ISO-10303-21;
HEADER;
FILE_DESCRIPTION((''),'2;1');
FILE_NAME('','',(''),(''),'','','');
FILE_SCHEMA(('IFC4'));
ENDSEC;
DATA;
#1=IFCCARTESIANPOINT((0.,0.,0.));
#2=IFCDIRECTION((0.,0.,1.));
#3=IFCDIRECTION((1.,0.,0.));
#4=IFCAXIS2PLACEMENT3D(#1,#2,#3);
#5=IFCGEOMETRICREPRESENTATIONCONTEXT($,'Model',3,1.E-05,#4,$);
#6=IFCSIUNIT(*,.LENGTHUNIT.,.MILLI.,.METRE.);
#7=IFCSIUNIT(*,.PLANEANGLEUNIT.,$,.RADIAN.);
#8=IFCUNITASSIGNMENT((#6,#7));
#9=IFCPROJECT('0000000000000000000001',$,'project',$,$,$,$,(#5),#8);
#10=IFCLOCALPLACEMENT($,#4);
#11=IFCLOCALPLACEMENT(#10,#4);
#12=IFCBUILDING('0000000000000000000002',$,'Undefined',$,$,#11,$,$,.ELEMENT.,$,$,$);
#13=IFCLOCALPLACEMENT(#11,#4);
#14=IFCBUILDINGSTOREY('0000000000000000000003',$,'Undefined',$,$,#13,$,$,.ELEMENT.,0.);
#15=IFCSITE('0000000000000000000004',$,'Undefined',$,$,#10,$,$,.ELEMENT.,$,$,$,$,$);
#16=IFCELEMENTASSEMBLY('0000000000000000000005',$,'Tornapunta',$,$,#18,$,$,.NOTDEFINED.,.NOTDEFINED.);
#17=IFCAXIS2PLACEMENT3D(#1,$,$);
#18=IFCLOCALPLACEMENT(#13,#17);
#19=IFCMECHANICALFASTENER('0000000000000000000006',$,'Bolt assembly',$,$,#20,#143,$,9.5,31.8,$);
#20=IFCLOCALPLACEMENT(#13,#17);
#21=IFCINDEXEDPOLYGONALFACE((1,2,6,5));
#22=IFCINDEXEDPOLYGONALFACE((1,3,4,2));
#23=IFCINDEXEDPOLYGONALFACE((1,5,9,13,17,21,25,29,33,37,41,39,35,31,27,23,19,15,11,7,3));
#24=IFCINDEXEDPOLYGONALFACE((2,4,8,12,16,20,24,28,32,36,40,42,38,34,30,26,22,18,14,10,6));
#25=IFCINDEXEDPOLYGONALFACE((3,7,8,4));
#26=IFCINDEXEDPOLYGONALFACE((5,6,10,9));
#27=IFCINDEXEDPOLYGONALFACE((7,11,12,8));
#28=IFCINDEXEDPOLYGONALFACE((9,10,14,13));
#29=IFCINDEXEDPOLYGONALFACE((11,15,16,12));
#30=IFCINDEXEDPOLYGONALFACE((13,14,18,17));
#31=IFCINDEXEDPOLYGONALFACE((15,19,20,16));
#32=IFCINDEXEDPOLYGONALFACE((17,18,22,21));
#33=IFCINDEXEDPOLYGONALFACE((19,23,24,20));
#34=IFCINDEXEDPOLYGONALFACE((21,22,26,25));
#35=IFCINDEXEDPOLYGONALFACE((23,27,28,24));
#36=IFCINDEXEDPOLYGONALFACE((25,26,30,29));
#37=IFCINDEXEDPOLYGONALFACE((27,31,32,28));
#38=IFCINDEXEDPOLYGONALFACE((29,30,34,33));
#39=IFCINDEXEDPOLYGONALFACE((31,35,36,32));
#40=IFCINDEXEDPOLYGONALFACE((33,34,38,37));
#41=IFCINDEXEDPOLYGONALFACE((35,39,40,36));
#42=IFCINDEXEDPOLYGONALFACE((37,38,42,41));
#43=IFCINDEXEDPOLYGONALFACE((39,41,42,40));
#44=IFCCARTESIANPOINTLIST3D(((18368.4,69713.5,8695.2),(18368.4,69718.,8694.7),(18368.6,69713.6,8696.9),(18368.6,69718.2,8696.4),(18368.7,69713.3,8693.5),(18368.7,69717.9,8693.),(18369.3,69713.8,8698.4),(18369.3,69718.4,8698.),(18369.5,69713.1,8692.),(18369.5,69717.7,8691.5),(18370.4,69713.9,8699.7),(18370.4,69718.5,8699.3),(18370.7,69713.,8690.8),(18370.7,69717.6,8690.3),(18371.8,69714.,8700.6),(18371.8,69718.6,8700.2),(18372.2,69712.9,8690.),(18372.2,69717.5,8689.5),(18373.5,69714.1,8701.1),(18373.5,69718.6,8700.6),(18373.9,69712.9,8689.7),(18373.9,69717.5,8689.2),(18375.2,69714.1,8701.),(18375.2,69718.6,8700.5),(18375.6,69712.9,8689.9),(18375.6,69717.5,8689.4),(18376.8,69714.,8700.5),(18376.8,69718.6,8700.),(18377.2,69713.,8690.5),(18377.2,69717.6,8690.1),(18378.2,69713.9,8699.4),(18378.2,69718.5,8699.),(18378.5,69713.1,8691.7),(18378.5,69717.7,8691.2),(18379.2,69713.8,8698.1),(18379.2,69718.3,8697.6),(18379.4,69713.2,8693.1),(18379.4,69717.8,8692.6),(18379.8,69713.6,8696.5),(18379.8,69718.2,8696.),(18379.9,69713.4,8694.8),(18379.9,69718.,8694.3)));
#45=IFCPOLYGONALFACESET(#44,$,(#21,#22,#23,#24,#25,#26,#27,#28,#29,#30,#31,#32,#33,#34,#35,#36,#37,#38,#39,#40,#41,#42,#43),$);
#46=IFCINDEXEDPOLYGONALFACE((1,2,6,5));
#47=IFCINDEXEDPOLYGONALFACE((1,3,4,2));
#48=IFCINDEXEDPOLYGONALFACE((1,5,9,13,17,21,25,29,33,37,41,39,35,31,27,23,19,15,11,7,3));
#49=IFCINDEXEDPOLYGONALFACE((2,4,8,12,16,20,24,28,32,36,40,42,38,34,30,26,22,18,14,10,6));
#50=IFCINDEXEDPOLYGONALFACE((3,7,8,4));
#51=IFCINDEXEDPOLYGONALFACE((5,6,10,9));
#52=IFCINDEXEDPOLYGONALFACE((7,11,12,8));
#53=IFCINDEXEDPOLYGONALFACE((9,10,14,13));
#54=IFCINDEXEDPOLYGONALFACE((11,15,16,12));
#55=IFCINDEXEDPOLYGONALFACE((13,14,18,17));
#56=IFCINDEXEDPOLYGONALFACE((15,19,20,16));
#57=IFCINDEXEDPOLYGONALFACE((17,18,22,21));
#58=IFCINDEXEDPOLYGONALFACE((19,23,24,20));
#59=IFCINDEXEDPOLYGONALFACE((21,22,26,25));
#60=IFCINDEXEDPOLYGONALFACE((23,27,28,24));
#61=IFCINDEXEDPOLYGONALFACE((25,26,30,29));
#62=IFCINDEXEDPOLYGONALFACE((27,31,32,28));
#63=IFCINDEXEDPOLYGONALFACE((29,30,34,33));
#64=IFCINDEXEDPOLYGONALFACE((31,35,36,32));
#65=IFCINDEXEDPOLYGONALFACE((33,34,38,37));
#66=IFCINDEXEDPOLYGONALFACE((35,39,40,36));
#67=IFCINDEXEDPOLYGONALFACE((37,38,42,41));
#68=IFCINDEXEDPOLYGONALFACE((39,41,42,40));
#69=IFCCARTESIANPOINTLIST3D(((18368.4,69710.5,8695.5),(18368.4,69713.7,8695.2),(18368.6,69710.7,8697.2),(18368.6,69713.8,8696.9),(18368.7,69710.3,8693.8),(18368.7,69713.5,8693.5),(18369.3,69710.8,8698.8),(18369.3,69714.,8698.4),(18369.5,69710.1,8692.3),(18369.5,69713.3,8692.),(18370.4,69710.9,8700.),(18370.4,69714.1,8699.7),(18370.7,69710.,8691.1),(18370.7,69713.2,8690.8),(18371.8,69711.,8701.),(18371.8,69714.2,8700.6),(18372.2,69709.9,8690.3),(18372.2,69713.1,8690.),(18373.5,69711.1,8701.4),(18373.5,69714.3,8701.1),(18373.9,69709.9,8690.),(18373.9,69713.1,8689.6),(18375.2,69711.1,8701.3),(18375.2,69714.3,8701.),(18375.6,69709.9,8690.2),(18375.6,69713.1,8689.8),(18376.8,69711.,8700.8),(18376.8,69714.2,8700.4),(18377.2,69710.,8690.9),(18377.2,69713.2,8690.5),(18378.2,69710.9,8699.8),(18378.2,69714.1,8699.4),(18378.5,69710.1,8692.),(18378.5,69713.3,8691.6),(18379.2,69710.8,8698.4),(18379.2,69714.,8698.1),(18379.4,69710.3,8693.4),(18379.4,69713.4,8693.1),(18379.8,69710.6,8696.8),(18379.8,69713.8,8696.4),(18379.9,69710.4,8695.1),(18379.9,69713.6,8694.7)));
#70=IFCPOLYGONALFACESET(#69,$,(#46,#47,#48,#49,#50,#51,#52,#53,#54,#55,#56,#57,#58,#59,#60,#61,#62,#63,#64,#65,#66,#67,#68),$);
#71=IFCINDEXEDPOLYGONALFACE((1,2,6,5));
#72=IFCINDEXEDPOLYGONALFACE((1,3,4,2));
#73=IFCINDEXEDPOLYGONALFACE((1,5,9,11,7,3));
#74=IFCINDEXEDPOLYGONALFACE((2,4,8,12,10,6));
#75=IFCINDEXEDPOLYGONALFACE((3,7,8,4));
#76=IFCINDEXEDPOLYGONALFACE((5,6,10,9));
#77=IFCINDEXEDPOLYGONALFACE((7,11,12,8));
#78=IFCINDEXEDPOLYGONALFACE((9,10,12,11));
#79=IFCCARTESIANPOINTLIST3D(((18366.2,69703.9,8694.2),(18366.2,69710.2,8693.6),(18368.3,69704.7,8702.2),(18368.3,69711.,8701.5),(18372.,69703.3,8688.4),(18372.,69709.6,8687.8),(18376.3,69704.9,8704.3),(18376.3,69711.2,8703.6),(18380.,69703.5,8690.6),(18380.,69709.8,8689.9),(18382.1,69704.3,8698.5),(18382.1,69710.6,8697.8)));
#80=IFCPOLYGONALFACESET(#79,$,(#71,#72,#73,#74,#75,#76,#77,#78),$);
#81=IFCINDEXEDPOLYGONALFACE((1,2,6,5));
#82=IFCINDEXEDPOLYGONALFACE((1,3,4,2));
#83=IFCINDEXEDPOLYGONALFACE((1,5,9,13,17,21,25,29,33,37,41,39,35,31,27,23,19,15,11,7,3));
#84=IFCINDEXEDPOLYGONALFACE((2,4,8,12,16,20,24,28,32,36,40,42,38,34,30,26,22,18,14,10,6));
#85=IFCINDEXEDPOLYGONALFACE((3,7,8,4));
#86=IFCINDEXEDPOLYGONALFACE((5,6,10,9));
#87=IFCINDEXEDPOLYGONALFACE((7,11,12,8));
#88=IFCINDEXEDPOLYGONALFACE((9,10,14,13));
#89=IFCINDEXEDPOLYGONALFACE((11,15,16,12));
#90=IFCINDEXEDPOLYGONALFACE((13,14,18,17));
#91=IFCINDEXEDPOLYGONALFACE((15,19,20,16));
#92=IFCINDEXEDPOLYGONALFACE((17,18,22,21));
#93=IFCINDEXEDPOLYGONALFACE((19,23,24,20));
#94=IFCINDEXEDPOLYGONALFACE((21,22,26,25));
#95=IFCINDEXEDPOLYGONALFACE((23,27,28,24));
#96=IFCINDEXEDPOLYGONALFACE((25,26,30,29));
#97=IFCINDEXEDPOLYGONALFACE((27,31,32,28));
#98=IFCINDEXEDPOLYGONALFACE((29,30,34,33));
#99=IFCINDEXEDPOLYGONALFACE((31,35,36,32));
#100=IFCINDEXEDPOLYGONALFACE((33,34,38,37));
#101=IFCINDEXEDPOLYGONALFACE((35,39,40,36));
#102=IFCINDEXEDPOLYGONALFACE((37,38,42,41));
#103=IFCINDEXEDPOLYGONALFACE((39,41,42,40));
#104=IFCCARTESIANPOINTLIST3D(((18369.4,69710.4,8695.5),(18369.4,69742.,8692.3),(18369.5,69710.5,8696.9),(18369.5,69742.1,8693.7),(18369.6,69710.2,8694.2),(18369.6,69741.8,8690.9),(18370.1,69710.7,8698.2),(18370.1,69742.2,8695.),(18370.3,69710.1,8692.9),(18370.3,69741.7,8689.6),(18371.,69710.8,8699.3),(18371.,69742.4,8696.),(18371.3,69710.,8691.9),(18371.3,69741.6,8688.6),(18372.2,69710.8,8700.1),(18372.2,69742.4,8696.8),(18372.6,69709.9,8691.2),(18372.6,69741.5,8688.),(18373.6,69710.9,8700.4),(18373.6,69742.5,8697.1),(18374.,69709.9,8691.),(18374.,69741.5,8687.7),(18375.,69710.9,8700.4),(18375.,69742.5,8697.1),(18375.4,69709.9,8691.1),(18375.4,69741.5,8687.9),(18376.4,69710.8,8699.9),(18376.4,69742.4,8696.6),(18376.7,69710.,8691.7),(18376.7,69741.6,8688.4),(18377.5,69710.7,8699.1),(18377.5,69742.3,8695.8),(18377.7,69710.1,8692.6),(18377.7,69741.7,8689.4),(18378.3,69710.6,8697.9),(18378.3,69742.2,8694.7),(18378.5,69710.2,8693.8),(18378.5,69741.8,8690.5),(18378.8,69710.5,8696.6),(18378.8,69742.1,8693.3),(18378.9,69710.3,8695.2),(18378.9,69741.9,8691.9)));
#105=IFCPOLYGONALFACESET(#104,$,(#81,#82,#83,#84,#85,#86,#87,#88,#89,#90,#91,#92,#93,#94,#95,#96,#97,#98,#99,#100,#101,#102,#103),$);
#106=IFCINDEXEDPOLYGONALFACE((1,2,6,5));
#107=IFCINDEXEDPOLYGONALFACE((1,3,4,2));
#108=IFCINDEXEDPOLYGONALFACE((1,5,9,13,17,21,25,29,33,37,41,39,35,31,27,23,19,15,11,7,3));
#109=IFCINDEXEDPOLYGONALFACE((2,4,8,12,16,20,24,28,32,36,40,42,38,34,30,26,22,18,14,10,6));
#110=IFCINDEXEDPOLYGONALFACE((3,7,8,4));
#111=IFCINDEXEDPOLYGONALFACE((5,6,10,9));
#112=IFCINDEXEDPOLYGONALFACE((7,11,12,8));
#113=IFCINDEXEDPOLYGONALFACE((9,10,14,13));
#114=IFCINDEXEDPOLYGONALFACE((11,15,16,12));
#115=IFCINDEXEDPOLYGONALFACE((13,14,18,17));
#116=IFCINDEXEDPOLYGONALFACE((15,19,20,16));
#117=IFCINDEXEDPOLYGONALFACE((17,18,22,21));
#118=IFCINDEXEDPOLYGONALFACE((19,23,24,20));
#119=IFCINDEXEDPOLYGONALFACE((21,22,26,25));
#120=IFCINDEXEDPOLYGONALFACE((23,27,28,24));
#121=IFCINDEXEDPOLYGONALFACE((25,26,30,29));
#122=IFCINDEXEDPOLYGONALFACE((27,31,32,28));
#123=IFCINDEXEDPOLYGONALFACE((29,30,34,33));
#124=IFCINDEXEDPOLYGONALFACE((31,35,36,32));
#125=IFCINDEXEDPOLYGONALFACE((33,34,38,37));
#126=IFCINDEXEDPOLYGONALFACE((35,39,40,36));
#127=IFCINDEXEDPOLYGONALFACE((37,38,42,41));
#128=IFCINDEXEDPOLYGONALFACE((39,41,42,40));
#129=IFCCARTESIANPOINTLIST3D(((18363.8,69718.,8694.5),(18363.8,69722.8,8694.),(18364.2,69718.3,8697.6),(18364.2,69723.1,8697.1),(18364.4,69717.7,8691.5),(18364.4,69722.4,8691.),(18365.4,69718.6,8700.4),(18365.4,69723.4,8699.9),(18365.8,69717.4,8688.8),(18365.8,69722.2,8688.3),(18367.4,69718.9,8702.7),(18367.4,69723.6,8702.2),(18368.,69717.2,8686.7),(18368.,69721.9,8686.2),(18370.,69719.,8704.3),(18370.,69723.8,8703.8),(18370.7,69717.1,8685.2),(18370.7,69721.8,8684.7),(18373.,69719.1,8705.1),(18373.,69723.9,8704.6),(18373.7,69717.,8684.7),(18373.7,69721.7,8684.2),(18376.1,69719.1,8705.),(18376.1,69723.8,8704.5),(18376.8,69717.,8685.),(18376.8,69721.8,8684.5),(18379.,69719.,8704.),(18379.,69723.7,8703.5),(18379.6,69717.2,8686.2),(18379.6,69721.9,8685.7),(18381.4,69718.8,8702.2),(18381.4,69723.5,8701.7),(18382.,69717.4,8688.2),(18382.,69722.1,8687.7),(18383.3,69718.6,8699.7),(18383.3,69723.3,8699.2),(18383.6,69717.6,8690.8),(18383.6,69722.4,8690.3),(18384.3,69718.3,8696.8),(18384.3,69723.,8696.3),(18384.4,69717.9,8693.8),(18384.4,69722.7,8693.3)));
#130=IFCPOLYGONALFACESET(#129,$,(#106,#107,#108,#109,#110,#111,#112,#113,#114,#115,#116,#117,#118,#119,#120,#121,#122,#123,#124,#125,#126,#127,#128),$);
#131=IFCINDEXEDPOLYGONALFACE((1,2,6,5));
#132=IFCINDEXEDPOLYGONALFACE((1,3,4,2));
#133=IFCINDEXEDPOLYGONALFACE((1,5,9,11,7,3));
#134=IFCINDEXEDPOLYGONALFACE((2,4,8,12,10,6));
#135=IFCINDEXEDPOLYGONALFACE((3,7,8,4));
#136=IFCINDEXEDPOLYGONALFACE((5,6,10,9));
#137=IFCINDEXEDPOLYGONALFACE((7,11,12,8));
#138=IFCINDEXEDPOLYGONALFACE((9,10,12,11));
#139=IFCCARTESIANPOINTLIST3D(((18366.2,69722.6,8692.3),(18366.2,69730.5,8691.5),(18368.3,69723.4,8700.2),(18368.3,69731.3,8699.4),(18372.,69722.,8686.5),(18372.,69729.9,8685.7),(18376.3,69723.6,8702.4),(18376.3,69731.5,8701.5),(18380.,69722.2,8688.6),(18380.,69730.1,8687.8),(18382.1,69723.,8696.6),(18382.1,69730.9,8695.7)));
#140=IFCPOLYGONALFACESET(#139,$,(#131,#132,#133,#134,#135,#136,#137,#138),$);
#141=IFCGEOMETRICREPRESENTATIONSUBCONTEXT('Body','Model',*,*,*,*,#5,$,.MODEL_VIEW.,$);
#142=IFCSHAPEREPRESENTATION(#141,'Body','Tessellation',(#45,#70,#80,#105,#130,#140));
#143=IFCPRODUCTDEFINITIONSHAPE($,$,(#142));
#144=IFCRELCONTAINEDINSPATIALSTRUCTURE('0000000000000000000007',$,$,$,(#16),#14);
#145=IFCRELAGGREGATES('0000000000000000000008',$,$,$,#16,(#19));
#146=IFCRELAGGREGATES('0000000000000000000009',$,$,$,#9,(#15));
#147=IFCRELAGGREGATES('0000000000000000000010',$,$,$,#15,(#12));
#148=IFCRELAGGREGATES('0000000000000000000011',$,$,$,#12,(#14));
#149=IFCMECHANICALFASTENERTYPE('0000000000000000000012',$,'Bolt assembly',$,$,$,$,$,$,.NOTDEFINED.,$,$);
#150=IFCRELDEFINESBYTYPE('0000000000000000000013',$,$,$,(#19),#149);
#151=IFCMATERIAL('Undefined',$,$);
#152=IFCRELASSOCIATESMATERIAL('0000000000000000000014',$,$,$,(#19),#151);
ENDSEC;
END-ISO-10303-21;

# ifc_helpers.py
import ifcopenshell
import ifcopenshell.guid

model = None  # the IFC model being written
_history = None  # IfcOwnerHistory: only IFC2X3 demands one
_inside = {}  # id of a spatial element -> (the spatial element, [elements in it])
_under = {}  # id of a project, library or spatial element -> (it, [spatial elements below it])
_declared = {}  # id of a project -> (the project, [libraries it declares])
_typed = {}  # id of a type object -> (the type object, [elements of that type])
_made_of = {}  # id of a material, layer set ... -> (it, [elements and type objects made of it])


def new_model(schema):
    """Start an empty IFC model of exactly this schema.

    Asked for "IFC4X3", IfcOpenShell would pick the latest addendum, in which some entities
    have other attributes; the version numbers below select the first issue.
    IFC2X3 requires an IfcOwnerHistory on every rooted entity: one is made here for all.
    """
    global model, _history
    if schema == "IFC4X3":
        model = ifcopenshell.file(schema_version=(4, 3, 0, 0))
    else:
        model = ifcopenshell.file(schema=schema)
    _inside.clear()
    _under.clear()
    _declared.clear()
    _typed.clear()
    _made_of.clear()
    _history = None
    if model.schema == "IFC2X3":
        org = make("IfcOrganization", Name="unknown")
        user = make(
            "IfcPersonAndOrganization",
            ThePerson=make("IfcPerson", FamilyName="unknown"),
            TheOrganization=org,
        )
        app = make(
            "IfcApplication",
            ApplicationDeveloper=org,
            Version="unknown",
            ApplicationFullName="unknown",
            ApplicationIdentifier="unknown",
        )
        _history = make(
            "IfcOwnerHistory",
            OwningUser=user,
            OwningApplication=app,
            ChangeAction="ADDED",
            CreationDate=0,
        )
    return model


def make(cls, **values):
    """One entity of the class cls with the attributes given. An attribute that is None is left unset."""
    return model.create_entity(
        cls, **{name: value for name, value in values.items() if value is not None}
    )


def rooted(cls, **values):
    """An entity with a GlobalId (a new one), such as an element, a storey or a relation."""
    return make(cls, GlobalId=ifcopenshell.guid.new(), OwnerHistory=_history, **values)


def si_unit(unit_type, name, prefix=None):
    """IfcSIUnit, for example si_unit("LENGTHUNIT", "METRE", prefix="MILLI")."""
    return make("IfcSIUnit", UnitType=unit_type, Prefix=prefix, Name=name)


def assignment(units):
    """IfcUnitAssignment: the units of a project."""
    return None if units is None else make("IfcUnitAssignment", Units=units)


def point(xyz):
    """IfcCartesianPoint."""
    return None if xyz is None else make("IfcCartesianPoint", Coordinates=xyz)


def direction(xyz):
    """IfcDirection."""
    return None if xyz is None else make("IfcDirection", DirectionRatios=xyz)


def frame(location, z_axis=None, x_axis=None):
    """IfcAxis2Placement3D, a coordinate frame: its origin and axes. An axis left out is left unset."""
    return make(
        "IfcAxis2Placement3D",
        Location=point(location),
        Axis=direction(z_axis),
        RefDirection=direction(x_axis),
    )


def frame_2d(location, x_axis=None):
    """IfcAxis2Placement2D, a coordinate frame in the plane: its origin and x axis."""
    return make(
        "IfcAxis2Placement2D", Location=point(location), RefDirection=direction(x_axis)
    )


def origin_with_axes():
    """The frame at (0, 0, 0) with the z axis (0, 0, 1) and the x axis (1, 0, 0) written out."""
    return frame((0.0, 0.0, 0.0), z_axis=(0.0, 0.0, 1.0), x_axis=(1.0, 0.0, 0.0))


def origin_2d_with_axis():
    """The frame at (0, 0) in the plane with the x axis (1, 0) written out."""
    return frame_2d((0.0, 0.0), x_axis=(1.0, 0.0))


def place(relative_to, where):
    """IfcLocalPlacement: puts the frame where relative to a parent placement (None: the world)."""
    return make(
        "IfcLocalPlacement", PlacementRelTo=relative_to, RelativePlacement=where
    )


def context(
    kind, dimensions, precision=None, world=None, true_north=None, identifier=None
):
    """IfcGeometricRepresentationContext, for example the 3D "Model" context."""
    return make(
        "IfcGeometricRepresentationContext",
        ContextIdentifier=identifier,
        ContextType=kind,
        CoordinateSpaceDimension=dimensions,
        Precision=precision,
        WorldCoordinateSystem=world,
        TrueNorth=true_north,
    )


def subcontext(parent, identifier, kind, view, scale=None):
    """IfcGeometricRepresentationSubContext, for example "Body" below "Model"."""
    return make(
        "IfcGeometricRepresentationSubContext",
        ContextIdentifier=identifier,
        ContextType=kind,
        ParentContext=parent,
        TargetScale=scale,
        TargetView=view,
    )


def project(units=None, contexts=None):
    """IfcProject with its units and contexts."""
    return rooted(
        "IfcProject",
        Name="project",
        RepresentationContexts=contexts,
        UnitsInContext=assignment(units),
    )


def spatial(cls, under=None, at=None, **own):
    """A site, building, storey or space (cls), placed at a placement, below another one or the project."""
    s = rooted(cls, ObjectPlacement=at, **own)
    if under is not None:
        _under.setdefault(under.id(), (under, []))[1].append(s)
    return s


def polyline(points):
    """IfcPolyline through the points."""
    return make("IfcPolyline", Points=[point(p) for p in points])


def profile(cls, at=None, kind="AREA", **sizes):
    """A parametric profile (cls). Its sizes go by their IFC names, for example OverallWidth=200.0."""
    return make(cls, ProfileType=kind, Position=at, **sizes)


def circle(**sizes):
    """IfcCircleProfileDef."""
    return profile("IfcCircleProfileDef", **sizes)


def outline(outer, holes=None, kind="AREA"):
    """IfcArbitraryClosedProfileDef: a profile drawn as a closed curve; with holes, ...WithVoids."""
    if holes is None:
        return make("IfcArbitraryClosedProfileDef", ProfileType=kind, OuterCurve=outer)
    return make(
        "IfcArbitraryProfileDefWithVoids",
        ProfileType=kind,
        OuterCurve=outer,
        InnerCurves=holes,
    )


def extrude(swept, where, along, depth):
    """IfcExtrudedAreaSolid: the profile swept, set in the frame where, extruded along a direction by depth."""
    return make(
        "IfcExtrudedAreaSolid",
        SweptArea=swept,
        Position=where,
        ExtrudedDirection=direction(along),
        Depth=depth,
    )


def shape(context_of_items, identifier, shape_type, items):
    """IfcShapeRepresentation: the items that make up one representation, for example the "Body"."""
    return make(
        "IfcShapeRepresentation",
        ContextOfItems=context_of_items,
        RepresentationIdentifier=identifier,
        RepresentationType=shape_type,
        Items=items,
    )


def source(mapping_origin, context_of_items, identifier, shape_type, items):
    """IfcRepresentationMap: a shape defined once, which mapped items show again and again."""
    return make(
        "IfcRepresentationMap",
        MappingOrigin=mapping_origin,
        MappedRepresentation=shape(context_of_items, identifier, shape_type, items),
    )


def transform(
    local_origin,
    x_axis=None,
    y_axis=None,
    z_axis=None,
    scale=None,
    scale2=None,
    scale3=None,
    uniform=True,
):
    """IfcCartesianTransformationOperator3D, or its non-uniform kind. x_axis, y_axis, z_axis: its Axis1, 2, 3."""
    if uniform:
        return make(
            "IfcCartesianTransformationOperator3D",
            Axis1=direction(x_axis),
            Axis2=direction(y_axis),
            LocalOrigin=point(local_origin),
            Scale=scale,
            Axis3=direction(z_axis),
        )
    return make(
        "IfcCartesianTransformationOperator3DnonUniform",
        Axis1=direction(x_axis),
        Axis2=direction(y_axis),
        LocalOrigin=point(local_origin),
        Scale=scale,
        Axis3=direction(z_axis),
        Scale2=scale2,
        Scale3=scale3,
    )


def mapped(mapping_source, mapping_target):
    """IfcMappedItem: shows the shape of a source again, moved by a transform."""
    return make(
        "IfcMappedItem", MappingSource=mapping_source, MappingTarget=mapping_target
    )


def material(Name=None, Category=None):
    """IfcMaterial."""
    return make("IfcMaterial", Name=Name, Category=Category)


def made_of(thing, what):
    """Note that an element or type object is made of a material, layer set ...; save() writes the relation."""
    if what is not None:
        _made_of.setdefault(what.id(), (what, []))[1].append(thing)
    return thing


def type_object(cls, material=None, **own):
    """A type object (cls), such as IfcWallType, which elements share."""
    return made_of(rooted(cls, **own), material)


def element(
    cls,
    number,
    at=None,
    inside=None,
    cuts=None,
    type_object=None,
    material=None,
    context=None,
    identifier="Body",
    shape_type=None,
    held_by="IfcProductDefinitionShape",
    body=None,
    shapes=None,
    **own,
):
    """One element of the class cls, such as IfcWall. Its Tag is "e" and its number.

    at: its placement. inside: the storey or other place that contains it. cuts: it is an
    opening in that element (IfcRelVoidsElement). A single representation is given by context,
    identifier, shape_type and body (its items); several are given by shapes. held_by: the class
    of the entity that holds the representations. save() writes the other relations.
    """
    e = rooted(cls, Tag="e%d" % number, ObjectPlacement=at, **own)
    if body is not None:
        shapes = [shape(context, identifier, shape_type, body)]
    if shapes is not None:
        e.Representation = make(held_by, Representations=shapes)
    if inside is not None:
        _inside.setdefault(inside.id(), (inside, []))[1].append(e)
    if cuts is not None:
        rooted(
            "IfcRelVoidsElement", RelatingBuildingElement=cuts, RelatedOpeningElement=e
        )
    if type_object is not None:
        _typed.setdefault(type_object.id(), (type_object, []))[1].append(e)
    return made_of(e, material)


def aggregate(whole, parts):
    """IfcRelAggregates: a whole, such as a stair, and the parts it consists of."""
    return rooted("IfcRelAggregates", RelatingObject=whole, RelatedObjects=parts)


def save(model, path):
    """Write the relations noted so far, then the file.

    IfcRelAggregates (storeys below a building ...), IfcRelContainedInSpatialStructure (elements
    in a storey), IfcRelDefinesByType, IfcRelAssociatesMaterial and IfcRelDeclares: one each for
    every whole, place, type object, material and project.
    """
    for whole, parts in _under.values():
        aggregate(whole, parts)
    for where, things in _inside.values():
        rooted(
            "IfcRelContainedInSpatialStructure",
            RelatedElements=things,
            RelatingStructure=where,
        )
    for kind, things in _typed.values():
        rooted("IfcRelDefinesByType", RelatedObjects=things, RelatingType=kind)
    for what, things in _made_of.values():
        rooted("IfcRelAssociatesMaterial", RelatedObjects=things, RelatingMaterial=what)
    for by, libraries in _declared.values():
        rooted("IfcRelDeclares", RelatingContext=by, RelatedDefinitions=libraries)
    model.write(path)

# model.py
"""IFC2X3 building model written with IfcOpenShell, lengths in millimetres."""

from ifc_helpers import new_model, si_unit, frame, origin_with_axes, origin_2d_with_axis, place, context, subcontext, project, spatial, polyline, circle, outline, extrude, source, transform, mapped, material, type_object, element, aggregate, save


model = new_model("IFC2X3")

# Units and contexts
model_context = context("Model", 3, precision=1e-05, world=origin_with_axes())
body_context = subcontext(model_context, "Body", "Model", "MODEL_VIEW")
ifc_project = project(units=[si_unit("LENGTHUNIT", "METRE", prefix="MILLI"), si_unit("PLANEANGLEUNIT", "RADIAN")], contexts=[model_context])

# Site, building, storey
site_placement = place(None, origin_with_axes())
site = spatial("IfcSite", under=ifc_project, at=site_placement, Name="Undefined", CompositionType="ELEMENT")
building_placement = place(site_placement, origin_with_axes())
building = spatial("IfcBuilding", under=site, at=building_placement, Name="Undefined", CompositionType="ELEMENT")
storey_placement = place(building_placement, origin_with_axes())
storey = spatial("IfcBuildingStorey", under=building, at=storey_placement, Name="Undefined", CompositionType="ELEMENT", Elevation=0.0)

# Element assembly
assembly_1_placement = place(storey_placement, origin_with_axes())
assembly_1 = element("IfcElementAssembly", 1, at=assembly_1_placement, inside=storey, Name="Tornapunta", AssemblyPlace="NOTDEFINED", PredefinedType="NOTDEFINED")

# Shared definitions
ifc_material_1 = material(Name="Undefined")
mechanical_fastener_type = type_object("IfcMechanicalFastenerType", Name="Bolt assembly")

# Mechanical fastener
shared_shape_1 = source(origin_with_axes(), body_context, "Body", "SweptSolid", [
    extrude(circle(Radius=5.8, at=origin_2d_with_axis()), frame((0.0, -0.1, 0.0), z_axis=(0.0, 1.0, 0.0), x_axis=(1.0, 0.0, 0.0)), (0.0, 0.0, 1.0), 4.6),
    extrude(circle(Radius=5.8, at=origin_2d_with_axis()), frame((0.0, -3.1, 0.0), z_axis=(0.0, 1.0, 0.0), x_axis=(1.0, 0.0, 0.0)), (0.0, 0.0, 1.0), 3.2),
    extrude(outline(polyline([(7.1, -4.1), (7.1, 4.1), (0.0, 8.2), (-7.1, 4.1), (-7.1, -4.1), (0.0, -8.2), (7.1, -4.1)])), frame((0.0, -9.5, 0.0), z_axis=(0.0, 1.0, 0.0), x_axis=(1.0, 0.0, 0.0)), (0.0, 0.0, 1.0), 6.3),
    extrude(circle(Radius=4.8, at=origin_2d_with_axis()), frame((0.0, -3.2, 0.0), z_axis=(0.0, 1.0, 0.0), x_axis=(1.0, 0.0, 0.0)), (0.0, 0.0, 1.0), 31.8),
    extrude(circle(Radius=10.3, at=origin_2d_with_axis()), frame((0.0, 4.5, 0.0), z_axis=(0.0, 1.0, 0.0), x_axis=(1.0, 0.0, 0.0)), (0.0, 0.0, 1.0), 4.8),
    extrude(outline(polyline([(7.1, -4.1), (7.1, 4.1), (0.0, 8.2), (-7.1, 4.1), (-7.1, -4.1), (0.0, -8.2), (7.1, -4.1)])), frame((0.0, 9.3, 0.0), z_axis=(0.0, 1.0, 0.0), x_axis=(1.0, 0.0, 0.0)), (0.0, 0.0, 1.0), 7.9),
])
mechanical_fastener_1_placement = place(assembly_1_placement, frame((18374.1, 69713.6, 8695.4), z_axis=(-0.707107, 0.072947, 0.703334), x_axis=(0.707107, 0.072947, 0.703334)))
mechanical_fastener_1 = element("IfcMechanicalFastener", 2, at=mechanical_fastener_1_placement, type_object=mechanical_fastener_type, material=ifc_material_1, Name="Bolt assembly", NominalDiameter=9.5, NominalLength=31.8, context=body_context, shape_type="MappedRepresentation", body=[
    mapped(shared_shape_1, transform((0.0, 0.0, 0.0))),
])
aggregate(assembly_1, [mechanical_fastener_1])

save(model, "model.ifc")
